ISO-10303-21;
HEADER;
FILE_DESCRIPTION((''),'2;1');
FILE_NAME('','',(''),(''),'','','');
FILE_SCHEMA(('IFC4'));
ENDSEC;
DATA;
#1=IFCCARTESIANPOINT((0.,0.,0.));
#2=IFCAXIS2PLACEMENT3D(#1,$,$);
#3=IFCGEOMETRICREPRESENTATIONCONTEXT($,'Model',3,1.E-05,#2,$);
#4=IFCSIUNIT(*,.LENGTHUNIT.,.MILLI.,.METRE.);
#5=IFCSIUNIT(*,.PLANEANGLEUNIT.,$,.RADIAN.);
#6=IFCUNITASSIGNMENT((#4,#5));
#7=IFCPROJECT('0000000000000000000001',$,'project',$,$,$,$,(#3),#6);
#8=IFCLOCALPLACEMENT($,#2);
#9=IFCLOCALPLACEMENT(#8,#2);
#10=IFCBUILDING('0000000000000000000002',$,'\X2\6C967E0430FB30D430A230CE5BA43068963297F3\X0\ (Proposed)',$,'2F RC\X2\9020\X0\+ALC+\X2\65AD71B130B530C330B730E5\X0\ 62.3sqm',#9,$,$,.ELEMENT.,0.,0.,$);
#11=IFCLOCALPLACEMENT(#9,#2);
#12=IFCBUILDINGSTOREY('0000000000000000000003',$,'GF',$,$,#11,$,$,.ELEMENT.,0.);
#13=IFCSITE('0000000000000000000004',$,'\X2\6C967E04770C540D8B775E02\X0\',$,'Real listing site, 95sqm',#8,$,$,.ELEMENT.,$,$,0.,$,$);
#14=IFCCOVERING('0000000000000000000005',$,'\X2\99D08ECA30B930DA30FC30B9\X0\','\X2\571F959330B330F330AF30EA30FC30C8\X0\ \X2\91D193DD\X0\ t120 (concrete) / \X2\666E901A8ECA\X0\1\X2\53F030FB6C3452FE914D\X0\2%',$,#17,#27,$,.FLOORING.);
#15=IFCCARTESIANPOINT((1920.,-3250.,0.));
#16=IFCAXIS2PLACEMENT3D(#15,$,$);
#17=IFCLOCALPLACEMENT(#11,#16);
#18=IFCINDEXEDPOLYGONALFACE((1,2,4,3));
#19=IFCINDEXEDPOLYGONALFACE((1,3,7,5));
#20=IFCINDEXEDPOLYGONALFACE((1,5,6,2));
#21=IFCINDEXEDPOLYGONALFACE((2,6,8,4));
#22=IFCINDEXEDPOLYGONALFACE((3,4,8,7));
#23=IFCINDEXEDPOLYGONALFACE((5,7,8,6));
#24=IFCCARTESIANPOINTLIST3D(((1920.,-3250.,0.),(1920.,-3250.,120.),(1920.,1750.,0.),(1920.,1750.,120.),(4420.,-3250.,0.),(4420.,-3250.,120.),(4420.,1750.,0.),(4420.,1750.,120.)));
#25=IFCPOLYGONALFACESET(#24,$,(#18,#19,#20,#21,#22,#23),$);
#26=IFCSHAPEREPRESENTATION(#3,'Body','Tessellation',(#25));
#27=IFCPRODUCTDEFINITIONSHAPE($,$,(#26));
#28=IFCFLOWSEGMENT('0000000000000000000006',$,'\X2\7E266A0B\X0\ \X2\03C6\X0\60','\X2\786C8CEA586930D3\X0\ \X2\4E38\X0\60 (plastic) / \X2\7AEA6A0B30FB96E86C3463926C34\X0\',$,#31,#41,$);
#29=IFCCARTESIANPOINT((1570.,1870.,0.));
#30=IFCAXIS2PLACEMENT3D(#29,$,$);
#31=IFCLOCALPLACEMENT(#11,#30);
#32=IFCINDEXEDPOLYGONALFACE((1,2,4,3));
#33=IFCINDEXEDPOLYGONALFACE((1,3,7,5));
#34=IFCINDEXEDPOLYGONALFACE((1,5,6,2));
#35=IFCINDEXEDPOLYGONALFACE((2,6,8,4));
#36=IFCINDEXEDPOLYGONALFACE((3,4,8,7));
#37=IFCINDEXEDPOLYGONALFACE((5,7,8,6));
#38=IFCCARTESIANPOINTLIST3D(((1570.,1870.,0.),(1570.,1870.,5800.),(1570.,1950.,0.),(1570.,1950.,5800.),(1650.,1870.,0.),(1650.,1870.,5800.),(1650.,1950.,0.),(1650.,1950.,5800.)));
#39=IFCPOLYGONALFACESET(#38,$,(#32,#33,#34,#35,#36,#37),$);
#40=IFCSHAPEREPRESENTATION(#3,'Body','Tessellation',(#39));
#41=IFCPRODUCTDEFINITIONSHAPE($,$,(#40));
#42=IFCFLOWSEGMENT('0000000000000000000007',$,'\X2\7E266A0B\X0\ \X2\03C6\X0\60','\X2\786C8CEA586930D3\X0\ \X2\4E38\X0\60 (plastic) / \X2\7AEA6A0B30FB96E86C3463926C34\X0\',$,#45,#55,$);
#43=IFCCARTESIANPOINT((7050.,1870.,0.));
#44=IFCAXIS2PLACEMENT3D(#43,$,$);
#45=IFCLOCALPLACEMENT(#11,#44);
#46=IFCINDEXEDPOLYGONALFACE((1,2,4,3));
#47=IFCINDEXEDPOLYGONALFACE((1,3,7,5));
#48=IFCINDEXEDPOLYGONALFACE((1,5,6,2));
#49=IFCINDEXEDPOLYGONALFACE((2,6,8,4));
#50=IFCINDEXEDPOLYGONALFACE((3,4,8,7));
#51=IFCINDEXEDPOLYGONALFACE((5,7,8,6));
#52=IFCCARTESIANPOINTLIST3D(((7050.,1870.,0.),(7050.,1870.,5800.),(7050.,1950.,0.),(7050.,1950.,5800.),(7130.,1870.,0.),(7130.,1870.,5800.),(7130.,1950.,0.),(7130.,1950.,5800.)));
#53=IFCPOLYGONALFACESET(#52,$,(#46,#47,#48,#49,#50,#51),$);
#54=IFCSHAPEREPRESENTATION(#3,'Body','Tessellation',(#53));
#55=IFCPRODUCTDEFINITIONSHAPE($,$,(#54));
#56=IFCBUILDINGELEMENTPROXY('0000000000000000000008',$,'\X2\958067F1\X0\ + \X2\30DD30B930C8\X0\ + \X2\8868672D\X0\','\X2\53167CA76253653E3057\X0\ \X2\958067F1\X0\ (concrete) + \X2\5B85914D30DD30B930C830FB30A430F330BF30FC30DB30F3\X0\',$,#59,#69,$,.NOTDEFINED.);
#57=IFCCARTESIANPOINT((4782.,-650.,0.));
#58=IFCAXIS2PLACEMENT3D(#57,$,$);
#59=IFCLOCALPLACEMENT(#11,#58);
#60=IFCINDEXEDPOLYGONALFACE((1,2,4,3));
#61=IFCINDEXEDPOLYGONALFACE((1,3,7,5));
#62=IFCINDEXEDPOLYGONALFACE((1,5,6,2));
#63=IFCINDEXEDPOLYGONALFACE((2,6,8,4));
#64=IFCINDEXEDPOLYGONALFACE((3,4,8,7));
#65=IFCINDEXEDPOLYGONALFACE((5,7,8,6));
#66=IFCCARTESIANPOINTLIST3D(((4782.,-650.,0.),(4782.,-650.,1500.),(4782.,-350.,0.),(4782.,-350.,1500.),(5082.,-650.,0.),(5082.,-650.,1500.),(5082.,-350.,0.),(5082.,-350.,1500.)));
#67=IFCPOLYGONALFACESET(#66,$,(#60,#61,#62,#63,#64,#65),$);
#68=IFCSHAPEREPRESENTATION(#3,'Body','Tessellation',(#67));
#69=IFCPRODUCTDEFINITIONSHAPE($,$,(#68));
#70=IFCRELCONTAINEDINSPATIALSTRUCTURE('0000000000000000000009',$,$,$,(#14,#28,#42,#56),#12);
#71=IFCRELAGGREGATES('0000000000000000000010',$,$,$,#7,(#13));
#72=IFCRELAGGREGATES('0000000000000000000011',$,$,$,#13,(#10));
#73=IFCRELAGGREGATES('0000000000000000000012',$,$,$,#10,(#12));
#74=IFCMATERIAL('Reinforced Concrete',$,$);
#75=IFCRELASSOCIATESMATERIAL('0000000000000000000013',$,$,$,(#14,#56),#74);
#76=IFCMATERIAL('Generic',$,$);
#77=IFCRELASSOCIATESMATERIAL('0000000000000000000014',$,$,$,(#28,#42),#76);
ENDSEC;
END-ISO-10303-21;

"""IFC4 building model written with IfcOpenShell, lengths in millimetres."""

from ifc_helpers import new_model, si_unit, frame, frame_2d, origin, place, context, project, spatial, rectangle, extrude, material, element, save


model = new_model("IFC4")

# Units and contexts
model_context = context("Model", 3, precision=1e-05, world=origin())
ifc_project = project(units=[si_unit("LENGTHUNIT", "METRE", prefix="MILLI"), si_unit("PLANEANGLEUNIT", "RADIAN")], contexts=[model_context])

# Site, building, storey
site_placement = place(None, origin())
site = spatial("IfcSite", under=ifc_project, at=site_placement, Name="沖縄県名護市", ObjectType="Real listing site, 95sqm", CompositionType="ELEMENT", RefElevation=0.0)
building_placement = place(site_placement, origin())
building = spatial("IfcBuilding", under=site, at=building_placement, Name="沖縄・ピアノ室と防音 (Proposed)", ObjectType="2F RC造+ALC+断熱サッシュ 62.3sqm", CompositionType="ELEMENT", ElevationOfRefHeight=0.0, ElevationOfTerrain=0.0)
storey_placement = place(building_placement, origin())
storey = spatial("IfcBuildingStorey", under=building, at=storey_placement, Name="GF", CompositionType="ELEMENT", Elevation=0.0)

# Shared definitions
ifc_material_1 = material(Name="Reinforced Concrete")

# Covering
covering_1_placement = place(storey_placement, frame((1920.0, -3250.0, 0.0)))
element("IfcCovering", 1, at=covering_1_placement, inside=storey, material=ifc_material_1, Name="駐車スペース", Description="土間コンクリート 金鏝 t120 (concrete) / 普通車1台・水勾配2%", PredefinedType="FLOORING", context=model_context, shape_type="SweptSolid", body=[
    extrude(rectangle(XDim=2500.0, YDim=5000.0, at=frame_2d((1250.0, 2500.0))), frame((1920.0, -3250.0, 0.0)), (0.0, 0.0, 1.0), 120.0),
])

# Flow segments
ifc_material_2 = material(Name="Generic")
flow_segment_1_placement = place(storey_placement, frame((1570.0, 1870.0, 0.0)))
element("IfcFlowSegment", 2, at=flow_segment_1_placement, inside=storey, material=ifc_material_2, Name="縦樋 φ60", Description="硬質塩ビ 丸60 (plastic) / 竪樋・雨水排水", context=model_context, shape_type="SweptSolid", body=[
    extrude(rectangle(XDim=80.0, YDim=80.0, at=frame_2d((40.0, 40.0))), frame((1570.0, 1870.0, 0.0)), (0.0, 0.0, 1.0), 5800.0),
])
flow_segment_2_placement = place(storey_placement, frame((7050.0, 1870.0, 0.0)))
element("IfcFlowSegment", 3, at=flow_segment_2_placement, inside=storey, material=ifc_material_2, Name="縦樋 φ60", Description="硬質塩ビ 丸60 (plastic) / 竪樋・雨水排水", context=model_context, shape_type="SweptSolid", body=[
    extrude(rectangle(XDim=80.0, YDim=80.0, at=frame_2d((40.0, 40.0))), frame((7050.0, 1870.0, 0.0)), (0.0, 0.0, 1.0), 5800.0),
])

# Building element proxy
proxy_placement = place(storey_placement, frame((4782.0, -650.0, 0.0)))
element("IfcBuildingElementProxy", 4, at=proxy_placement, inside=storey, material=ifc_material_1, Name="門柱 + ポスト + 表札", Description="化粧打放し 門柱 (concrete) + 宅配ポスト・インターホン", PredefinedType="NOTDEFINED", context=model_context, shape_type="SweptSolid", body=[
    extrude(rectangle(XDim=300.0, YDim=300.0, at=frame_2d((150.0, 150.0))), frame((4782.0, -650.0, 0.0)), (0.0, 0.0, 1.0), 1500.0),
])

save(model, "model.ifc")
